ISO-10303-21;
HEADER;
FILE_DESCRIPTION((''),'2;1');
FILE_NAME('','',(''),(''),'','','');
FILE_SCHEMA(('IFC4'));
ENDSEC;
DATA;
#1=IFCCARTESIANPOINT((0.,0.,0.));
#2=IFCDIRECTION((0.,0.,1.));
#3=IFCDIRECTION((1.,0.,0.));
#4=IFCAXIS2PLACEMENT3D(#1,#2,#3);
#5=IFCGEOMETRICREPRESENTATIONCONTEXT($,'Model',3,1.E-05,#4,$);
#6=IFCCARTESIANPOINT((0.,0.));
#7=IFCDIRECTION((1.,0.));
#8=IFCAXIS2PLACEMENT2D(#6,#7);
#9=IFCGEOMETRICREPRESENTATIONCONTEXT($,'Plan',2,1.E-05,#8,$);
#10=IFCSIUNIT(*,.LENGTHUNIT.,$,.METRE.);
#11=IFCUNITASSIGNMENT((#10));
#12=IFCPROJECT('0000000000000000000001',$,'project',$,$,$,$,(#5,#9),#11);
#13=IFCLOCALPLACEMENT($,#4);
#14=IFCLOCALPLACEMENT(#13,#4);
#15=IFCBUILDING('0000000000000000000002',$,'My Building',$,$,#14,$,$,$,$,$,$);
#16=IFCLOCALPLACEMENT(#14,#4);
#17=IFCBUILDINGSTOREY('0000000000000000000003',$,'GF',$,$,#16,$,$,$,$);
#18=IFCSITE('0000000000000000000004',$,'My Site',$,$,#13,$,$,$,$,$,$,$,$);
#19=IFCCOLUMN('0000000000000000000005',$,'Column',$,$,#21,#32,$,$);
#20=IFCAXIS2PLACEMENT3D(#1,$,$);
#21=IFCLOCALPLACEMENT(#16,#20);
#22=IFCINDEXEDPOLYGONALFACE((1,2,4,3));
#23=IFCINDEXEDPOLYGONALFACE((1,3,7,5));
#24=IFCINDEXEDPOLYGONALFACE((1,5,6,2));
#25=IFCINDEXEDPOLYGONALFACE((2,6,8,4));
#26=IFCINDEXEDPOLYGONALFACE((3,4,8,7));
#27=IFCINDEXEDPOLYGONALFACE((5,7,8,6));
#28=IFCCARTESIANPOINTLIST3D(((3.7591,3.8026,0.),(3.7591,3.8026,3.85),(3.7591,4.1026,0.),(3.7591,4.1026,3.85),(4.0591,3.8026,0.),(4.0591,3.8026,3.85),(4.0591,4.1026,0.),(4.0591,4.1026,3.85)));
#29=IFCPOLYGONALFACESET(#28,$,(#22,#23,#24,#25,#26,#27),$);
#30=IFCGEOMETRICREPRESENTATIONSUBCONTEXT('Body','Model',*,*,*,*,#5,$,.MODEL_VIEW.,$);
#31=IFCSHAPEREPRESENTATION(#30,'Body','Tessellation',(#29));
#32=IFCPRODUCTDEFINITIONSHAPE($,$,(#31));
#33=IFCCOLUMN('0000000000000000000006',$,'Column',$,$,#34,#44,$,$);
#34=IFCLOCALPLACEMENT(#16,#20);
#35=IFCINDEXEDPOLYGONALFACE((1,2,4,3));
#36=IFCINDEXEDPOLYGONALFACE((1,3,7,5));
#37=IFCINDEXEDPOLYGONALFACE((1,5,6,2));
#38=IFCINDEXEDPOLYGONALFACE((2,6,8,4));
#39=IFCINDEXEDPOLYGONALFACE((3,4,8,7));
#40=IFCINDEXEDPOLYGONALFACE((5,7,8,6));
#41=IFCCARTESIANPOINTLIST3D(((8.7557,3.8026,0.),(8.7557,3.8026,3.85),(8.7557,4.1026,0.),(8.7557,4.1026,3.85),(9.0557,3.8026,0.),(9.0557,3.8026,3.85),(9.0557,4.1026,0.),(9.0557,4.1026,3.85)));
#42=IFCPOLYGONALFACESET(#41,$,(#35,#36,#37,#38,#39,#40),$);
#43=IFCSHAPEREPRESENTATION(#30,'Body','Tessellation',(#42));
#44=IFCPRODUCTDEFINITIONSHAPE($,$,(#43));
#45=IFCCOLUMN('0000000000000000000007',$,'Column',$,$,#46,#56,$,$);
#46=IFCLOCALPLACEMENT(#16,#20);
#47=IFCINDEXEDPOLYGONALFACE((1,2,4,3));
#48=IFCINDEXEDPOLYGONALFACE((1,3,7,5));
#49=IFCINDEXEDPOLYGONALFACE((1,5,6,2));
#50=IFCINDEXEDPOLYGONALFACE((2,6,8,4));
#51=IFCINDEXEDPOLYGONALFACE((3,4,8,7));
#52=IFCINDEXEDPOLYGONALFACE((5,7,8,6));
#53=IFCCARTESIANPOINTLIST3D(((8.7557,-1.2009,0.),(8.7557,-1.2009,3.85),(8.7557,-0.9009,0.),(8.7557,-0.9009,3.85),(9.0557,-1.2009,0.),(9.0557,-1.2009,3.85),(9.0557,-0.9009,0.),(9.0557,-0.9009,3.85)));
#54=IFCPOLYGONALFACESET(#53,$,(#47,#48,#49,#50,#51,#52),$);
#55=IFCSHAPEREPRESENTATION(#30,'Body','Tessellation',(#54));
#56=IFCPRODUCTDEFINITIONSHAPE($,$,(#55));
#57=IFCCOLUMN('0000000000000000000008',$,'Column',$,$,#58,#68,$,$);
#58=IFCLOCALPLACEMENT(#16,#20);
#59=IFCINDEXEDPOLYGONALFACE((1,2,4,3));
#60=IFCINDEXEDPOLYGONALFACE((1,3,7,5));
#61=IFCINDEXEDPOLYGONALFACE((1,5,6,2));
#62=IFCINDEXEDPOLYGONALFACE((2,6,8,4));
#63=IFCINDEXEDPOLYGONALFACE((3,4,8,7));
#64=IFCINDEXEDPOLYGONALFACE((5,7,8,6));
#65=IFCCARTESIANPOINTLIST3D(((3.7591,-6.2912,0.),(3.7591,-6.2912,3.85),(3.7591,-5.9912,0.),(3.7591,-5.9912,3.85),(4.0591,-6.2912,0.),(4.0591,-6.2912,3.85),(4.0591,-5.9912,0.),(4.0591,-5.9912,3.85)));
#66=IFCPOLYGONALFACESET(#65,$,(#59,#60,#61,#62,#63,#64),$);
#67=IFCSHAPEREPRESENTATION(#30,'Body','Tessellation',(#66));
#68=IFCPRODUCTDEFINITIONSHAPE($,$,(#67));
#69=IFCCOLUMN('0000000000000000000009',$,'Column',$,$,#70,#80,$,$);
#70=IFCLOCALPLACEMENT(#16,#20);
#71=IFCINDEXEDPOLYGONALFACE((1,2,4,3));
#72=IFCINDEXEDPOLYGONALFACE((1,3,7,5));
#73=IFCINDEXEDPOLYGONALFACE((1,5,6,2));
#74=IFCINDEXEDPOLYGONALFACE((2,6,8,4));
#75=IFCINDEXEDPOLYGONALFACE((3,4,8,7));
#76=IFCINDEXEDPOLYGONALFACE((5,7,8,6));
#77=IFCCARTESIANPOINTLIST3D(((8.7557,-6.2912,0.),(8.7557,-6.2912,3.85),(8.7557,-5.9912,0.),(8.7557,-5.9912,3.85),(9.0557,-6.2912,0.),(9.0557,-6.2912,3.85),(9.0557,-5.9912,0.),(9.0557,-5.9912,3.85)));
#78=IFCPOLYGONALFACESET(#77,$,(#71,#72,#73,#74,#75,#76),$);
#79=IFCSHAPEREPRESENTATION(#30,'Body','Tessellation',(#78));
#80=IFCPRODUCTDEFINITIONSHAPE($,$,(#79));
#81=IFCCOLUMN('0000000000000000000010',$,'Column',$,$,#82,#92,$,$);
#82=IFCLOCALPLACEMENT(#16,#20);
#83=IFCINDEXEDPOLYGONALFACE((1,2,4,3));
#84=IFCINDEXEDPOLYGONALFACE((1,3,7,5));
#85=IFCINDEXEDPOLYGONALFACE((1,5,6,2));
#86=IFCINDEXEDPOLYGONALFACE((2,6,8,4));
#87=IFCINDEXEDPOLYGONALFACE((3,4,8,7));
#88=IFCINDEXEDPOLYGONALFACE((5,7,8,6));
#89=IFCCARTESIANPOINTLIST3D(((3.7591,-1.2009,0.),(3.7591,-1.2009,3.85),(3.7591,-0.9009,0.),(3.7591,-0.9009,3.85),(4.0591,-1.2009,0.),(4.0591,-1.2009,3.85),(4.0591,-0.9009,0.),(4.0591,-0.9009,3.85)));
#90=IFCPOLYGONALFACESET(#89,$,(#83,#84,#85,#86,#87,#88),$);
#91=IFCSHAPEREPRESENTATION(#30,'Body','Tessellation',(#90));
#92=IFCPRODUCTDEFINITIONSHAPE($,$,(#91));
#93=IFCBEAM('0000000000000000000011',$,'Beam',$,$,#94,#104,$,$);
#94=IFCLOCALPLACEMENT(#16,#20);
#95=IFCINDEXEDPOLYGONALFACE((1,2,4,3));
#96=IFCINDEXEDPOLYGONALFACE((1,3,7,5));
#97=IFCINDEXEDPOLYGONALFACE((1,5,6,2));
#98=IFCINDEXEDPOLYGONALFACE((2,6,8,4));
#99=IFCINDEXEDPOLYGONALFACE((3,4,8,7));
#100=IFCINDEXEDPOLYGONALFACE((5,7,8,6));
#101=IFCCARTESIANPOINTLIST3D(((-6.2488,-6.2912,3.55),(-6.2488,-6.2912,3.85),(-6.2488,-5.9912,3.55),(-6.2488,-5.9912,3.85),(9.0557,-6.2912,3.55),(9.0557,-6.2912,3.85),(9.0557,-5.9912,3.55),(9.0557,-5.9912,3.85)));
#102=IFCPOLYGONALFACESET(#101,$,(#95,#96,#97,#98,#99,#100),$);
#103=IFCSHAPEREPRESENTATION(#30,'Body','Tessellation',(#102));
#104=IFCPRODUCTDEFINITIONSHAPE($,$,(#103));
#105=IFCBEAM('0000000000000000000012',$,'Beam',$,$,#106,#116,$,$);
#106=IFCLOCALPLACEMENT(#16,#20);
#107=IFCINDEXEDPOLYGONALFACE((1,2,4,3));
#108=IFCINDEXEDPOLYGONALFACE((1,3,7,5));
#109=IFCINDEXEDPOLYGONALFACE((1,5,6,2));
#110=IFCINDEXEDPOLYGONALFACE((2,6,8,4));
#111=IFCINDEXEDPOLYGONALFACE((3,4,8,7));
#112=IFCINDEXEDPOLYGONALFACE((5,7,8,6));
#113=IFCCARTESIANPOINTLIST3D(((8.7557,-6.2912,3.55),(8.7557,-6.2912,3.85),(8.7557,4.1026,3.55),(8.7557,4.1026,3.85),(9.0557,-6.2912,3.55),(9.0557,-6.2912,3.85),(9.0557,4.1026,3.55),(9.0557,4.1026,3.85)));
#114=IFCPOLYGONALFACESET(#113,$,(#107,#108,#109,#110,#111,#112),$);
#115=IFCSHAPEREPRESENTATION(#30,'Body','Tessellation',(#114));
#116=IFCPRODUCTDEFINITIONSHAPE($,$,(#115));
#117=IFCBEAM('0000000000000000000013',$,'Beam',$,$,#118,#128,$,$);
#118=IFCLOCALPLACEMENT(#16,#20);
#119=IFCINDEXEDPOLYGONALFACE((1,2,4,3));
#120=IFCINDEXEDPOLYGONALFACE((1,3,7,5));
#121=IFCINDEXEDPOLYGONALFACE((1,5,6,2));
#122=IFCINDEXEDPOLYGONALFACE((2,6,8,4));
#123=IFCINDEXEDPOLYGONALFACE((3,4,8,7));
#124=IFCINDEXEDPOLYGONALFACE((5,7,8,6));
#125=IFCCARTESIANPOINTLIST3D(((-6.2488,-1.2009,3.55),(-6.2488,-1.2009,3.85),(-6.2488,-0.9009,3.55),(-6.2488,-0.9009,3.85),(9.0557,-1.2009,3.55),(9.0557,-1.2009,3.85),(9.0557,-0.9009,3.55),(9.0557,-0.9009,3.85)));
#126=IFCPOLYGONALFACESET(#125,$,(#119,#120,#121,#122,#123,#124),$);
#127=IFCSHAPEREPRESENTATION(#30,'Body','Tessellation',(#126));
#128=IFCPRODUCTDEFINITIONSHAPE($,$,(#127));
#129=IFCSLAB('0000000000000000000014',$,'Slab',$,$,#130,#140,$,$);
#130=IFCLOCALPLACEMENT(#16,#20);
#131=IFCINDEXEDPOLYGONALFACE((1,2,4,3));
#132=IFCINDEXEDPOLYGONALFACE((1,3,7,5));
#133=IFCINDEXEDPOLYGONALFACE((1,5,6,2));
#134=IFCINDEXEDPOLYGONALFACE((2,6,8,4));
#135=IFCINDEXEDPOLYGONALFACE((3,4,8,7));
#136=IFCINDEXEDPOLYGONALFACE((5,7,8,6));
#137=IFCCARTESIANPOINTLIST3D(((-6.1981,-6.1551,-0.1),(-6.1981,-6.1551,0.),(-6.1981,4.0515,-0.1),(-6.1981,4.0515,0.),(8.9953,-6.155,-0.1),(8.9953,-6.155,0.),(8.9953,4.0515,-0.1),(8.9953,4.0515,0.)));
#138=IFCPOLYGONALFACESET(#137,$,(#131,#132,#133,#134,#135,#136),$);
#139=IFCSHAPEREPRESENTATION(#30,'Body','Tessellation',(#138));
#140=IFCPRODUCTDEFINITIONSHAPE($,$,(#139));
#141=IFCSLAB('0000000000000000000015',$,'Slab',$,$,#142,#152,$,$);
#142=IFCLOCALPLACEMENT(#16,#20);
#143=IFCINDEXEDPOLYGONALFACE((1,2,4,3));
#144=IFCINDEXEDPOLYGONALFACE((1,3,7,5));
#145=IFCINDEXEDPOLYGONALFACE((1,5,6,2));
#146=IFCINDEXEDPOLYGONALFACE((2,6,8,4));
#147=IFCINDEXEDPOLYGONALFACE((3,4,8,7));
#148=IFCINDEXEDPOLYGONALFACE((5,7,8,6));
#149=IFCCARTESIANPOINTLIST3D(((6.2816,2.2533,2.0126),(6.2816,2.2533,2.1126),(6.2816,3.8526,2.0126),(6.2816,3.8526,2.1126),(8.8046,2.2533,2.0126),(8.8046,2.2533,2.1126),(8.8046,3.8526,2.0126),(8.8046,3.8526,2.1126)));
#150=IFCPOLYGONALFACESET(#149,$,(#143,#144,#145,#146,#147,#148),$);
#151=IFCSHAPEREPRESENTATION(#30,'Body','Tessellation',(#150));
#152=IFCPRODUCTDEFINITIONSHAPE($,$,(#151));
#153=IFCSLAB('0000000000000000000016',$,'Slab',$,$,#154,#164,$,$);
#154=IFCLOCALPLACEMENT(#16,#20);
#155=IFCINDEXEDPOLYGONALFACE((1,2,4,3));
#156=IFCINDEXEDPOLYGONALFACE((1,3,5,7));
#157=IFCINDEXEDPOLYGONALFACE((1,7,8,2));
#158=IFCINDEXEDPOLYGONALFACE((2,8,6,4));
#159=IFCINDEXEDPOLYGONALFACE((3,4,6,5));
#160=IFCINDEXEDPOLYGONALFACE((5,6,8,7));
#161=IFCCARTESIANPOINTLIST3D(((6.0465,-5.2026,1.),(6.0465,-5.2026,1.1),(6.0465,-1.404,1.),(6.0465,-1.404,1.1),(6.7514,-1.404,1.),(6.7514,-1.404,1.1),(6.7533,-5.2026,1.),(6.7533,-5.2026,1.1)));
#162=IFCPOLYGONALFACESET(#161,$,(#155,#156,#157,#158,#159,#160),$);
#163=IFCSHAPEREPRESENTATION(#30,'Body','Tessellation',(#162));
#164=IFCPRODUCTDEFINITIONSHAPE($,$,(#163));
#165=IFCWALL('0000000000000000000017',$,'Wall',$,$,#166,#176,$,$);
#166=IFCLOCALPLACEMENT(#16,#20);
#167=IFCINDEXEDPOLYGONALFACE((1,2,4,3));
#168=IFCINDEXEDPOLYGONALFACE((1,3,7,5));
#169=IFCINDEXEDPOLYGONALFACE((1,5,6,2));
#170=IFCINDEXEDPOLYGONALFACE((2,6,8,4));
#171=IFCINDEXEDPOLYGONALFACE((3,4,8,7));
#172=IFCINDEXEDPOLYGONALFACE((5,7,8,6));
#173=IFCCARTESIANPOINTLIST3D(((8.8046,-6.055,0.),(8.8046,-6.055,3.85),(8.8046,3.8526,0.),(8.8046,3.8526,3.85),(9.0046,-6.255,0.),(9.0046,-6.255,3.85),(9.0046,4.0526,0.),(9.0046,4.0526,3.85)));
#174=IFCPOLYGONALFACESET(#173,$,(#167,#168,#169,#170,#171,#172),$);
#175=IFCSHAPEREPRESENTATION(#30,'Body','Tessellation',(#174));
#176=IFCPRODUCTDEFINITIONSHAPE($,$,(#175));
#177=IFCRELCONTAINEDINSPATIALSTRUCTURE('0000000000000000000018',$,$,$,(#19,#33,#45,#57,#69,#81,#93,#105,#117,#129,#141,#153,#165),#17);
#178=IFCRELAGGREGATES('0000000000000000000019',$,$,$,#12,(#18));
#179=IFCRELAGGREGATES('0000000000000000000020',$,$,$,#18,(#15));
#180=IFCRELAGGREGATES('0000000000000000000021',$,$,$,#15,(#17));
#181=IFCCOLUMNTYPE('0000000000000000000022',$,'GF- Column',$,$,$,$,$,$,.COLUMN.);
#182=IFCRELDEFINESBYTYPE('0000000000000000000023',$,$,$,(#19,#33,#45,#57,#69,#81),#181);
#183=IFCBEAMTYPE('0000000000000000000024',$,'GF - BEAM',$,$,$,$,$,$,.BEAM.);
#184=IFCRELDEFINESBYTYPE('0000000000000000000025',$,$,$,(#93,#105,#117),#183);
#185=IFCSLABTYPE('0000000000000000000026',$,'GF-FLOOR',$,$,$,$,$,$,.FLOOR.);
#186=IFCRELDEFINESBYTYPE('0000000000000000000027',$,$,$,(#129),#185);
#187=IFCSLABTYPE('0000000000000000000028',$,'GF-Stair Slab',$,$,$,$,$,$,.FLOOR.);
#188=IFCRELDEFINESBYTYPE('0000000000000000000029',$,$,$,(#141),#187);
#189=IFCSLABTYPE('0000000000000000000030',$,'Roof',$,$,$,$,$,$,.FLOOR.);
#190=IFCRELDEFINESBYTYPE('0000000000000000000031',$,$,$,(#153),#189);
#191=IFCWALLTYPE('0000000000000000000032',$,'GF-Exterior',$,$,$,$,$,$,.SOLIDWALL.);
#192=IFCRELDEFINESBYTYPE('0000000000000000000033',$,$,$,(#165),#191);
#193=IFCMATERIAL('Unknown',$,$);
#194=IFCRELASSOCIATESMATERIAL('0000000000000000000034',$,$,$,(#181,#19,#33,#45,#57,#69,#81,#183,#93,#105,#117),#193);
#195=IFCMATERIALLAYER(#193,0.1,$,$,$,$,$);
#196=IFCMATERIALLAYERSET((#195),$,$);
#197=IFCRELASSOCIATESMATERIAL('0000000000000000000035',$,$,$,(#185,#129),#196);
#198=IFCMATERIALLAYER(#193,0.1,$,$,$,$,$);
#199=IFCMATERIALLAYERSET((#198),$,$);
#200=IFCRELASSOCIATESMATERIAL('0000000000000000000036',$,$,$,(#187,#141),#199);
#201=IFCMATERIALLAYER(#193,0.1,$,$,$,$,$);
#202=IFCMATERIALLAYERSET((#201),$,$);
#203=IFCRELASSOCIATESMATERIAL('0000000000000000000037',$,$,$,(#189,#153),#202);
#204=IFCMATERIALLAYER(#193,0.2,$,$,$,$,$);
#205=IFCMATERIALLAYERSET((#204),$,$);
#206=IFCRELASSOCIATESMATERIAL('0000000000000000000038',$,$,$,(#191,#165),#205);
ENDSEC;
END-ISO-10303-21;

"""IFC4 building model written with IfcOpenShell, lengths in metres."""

from ifc_helpers import new_model, si_unit, frame, origin_with_axes, origin_2d_with_axis, place, context, subcontext, project, spatial, line, indexed_curve, rectangle, outline, extrude, material, layer, layer_set, layer_usage, material_profile, profile_set, profile_usage, type_object, element, save


model = new_model("IFC4")

# Units and contexts
model_context = context("Model", 3, precision=1e-05, world=origin_with_axes())
plan_context = context("Plan", 2, precision=1e-05, world=origin_2d_with_axis())
body_context_1 = subcontext(model_context, "Body", "Model", "MODEL_VIEW")
ifc_project = project(units=[si_unit("LENGTHUNIT", "METRE")], contexts=[model_context, plan_context])

# Site, building, storey
site_placement = place(None, origin_with_axes())
site = spatial("IfcSite", under=ifc_project, at=site_placement, Name="My Site")
building_placement = place(site_placement, origin_with_axes())
building = spatial("IfcBuilding", under=site, at=building_placement, Name="My Building")
storey_placement = place(building_placement, origin_with_axes())
storey = spatial("IfcBuildingStorey", under=building, at=storey_placement, Name="GF")

# Columns
ifc_material = material(Name="Unknown")
ifc_material_profile_1 = material_profile(ifc_material, rectangle(XDim=0.3, YDim=0.3))
ifc_profile_set_1 = profile_set([ifc_material_profile_1])
ifc_profile_usage_1 = profile_usage(ifc_profile_set_1, cardinal=5)
column_type = type_object("IfcColumnType", Name="GF- Column", PredefinedType="COLUMN", material=ifc_profile_set_1)
column_1_placement = place(storey_placement, frame((3.9091, 3.9526, 0.0), z_axis=(0.0, 0.0, 1.0), x_axis=(1.0, 0.0, 0.0)))
element("IfcColumn", 1, at=column_1_placement, inside=storey, type_object=column_type, material=ifc_profile_usage_1, Name="Column", context=body_context_1, shape_type="SweptSolid", body=[
    extrude(rectangle(XDim=0.3, YDim=0.3), origin_with_axes(), (0.0, 0.0, 1.0), 3.85),
])
ifc_profile_usage_2 = profile_usage(ifc_profile_set_1, cardinal=5)
column_2_placement = place(storey_placement, frame((8.9057, 3.9526, 0.0), z_axis=(0.0, 0.0, 1.0), x_axis=(1.0, 0.0, 0.0)))
element("IfcColumn", 2, at=column_2_placement, inside=storey, type_object=column_type, material=ifc_profile_usage_2, Name="Column", context=body_context_1, shape_type="SweptSolid", body=[
    extrude(rectangle(XDim=0.3, YDim=0.3), origin_with_axes(), (0.0, 0.0, 1.0), 3.85),
])
ifc_profile_usage_3 = profile_usage(ifc_profile_set_1, cardinal=5)
column_3_placement = place(storey_placement, frame((8.9057, -1.0509, 0.0), z_axis=(0.0, 0.0, 1.0), x_axis=(1.0, 0.0, 0.0)))
element("IfcColumn", 3, at=column_3_placement, inside=storey, type_object=column_type, material=ifc_profile_usage_3, Name="Column", context=body_context_1, shape_type="SweptSolid", body=[
    extrude(rectangle(XDim=0.3, YDim=0.3), origin_with_axes(), (0.0, 0.0, 1.0), 3.85),
])
ifc_profile_usage_4 = profile_usage(ifc_profile_set_1, cardinal=5)
column_4_placement = place(storey_placement, frame((3.9091, -6.1412, 0.0), z_axis=(0.0, 0.0, 1.0), x_axis=(1.0, 0.0, 0.0)))
element("IfcColumn", 4, at=column_4_placement, inside=storey, type_object=column_type, material=ifc_profile_usage_4, Name="Column", context=body_context_1, shape_type="SweptSolid", body=[
    extrude(rectangle(XDim=0.3, YDim=0.3), origin_with_axes(), (0.0, 0.0, 1.0), 3.85),
])
ifc_profile_usage_5 = profile_usage(ifc_profile_set_1, cardinal=5)
column_5_placement = place(storey_placement, frame((8.9057, -6.1412, 0.0), z_axis=(0.0, 0.0, 1.0), x_axis=(1.0, 0.0, 0.0)))
element("IfcColumn", 5, at=column_5_placement, inside=storey, type_object=column_type, material=ifc_profile_usage_5, Name="Column", context=body_context_1, shape_type="SweptSolid", body=[
    extrude(rectangle(XDim=0.3, YDim=0.3), origin_with_axes(), (0.0, 0.0, 1.0), 3.85),
])
ifc_profile_usage_6 = profile_usage(ifc_profile_set_1, cardinal=5)
column_6_placement = place(storey_placement, frame((3.9091, -1.0509, 0.0), z_axis=(0.0, 0.0, 1.0), x_axis=(1.0, 0.0, 0.0)))
element("IfcColumn", 6, at=column_6_placement, inside=storey, type_object=column_type, material=ifc_profile_usage_6, Name="Column", context=body_context_1, shape_type="SweptSolid", body=[
    extrude(rectangle(XDim=0.3, YDim=0.3), origin_with_axes(), (0.0, 0.0, 1.0), 3.85),
])

# Beams
ifc_material_profile_2 = material_profile(ifc_material, rectangle(XDim=0.3, YDim=0.3))
ifc_profile_set_2 = profile_set([ifc_material_profile_2])
ifc_profile_usage_7 = profile_usage(ifc_profile_set_2, cardinal=5)
beam_type = type_object("IfcBeamType", Name="GF - BEAM", PredefinedType="BEAM", material=ifc_profile_set_2)
beam_1_placement = place(storey_placement, frame((9.0557, -6.1412, 3.7), z_axis=(-1.0, 0.0, 0.0), x_axis=(0.0, -1.0, 0.0)))
element("IfcBeam", 7, at=beam_1_placement, inside=storey, type_object=beam_type, material=ifc_profile_usage_7, Name="Beam", context=body_context_1, shape_type="SweptSolid", body=[
    extrude(rectangle(XDim=0.3, YDim=0.3), origin_with_axes(), (0.0, 0.0, 1.0), 15.3045),
])
ifc_profile_usage_8 = profile_usage(ifc_profile_set_2, cardinal=5)
beam_2_placement = place(storey_placement, frame((8.9057, -6.2912, 3.7), z_axis=(0.0, 1.0, 0.0), x_axis=(-1.0, 0.0, 0.0)))
element("IfcBeam", 8, at=beam_2_placement, inside=storey, type_object=beam_type, material=ifc_profile_usage_8, Name="Beam", context=body_context_1, shape_type="SweptSolid", body=[
    extrude(rectangle(XDim=0.3, YDim=0.3), origin_with_axes(), (0.0, 0.0, 1.0), 10.3938),
])
ifc_profile_usage_9 = profile_usage(ifc_profile_set_2, cardinal=5)
beam_3_placement = place(storey_placement, frame((9.0557, -1.0509, 3.7), z_axis=(-1.0, 0.0, 0.0), x_axis=(0.0, -1.0, 0.0)))
element("IfcBeam", 9, at=beam_3_placement, inside=storey, type_object=beam_type, material=ifc_profile_usage_9, Name="Beam", context=body_context_1, shape_type="SweptSolid", body=[
    extrude(rectangle(XDim=0.3, YDim=0.3), origin_with_axes(), (0.0, 0.0, 1.0), 15.3045),
])

# Slabs
ifc_layer_1 = layer(ifc_material, 0.1)
ifc_layer_set_1 = layer_set([ifc_layer_1])
ifc_layer_usage_1 = layer_usage(ifc_layer_set_1, "AXIS3", "POSITIVE", -0.1)
slab_type_1 = type_object("IfcSlabType", Name="GF-FLOOR", PredefinedType="FLOOR", material=ifc_layer_set_1)
slab_1_placement = place(storey_placement, frame((8.9953, -6.155, 0.0), z_axis=(0.0, 0.0, 1.0), x_axis=(1.0, 0.0, 0.0)))
element("IfcSlab", 10, at=slab_1_placement, inside=storey, type_object=slab_type_1, material=ifc_layer_usage_1, Name="Slab", context=body_context_1, shape_type="SweptSolid", body=[
    extrude(outline(indexed_curve([(0.0, 0.0), (0.0, 10.2065), (-15.1934, 10.2065), (-15.1934, -0.0001), (0.0, 0.0)])), frame((0.0, 0.0, -0.1), z_axis=(0.0, 0.0, 1.0), x_axis=(1.0, 0.0, 0.0)), (0.0, 0.0, 1.0), 0.1),
])
ifc_layer_2 = layer(ifc_material, 0.1)
ifc_layer_set_2 = layer_set([ifc_layer_2])
ifc_layer_usage_2 = layer_usage(ifc_layer_set_2, "AXIS3", "POSITIVE", -0.1)
slab_type_2 = type_object("IfcSlabType", Name="GF-Stair Slab", PredefinedType="FLOOR", material=ifc_layer_set_2)
slab_2_placement = place(storey_placement, frame((6.2816, 3.8526, 2.1126), z_axis=(0.0, 0.0, 1.0), x_axis=(1.0, 0.0, 0.0)))
element("IfcSlab", 11, at=slab_2_placement, inside=storey, type_object=slab_type_2, material=ifc_layer_usage_2, Name="Slab", context=body_context_1, shape_type="SweptSolid", body=[
    extrude(outline(indexed_curve([(0.0, 0.0), (0.0, -1.5993), (2.5231, -1.5993), (2.5231, 0.0), (0.0, 0.0)])), frame((0.0, 0.0, -0.1), z_axis=(0.0, 0.0, 1.0), x_axis=(1.0, 0.0, 0.0)), (0.0, 0.0, 1.0), 0.1),
])
ifc_layer_3 = layer(ifc_material, 0.1)
ifc_layer_set_3 = layer_set([ifc_layer_3])
ifc_layer_usage_3 = layer_usage(ifc_layer_set_3, "AXIS3", "POSITIVE", -0.1)
slab_type_3 = type_object("IfcSlabType", Name="Roof", PredefinedType="FLOOR", material=ifc_layer_set_3)
slab_3_placement = place(storey_placement, frame((6.7533, -5.2026, 1.1), z_axis=(0.0, 0.0, 1.0), x_axis=(1.0, 0.0, 0.0)))
element("IfcSlab", 12, at=slab_3_placement, inside=storey, type_object=slab_type_3, material=ifc_layer_usage_3, Name="Slab", context=body_context_1, shape_type="SweptSolid", body=[
    extrude(outline(indexed_curve([(0.0, 0.0), (-0.7068, 0.0), (-0.7067, 3.7986), (-0.0019, 3.7986), (0.0, 0.0)])), frame((0.0, 0.0, -0.1), z_axis=(0.0, 0.0, 1.0), x_axis=(1.0, 0.0, 0.0)), (0.0, 0.0, 1.0), 0.1),
])

# Wall
ifc_layer_4 = layer(ifc_material, 0.2)
ifc_layer_set_4 = layer_set([ifc_layer_4])
ifc_layer_usage_4 = layer_usage(ifc_layer_set_4, "AXIS2", "POSITIVE", 0.0)
wall_type_1 = type_object("IfcWallType", Name="GF-Exterior", PredefinedType="SOLIDWALL", material=ifc_layer_set_4)
wall_1_placement = place(storey_placement, frame((8.8046, 3.8526, 0.0), z_axis=(0.0, 0.0, 1.0), x_axis=(0.0, -1.0, 0.0)))
element("IfcWall", 13, at=wall_1_placement, inside=storey, type_object=wall_type_1, material=ifc_layer_usage_4, Name="Wall", context=body_context_1, shape_type="SweptSolid", body=[
    extrude(outline(indexed_curve([(0.0, 0.0), (-0.2, 0.2), (10.1077, 0.2), (9.9077, 0.0)], segments=[line(1, 2, 3, 4, 1)])), origin_with_axes(), (0.0, 0.0, 1.0), 3.85),
])

save(model, "model.ifc")
